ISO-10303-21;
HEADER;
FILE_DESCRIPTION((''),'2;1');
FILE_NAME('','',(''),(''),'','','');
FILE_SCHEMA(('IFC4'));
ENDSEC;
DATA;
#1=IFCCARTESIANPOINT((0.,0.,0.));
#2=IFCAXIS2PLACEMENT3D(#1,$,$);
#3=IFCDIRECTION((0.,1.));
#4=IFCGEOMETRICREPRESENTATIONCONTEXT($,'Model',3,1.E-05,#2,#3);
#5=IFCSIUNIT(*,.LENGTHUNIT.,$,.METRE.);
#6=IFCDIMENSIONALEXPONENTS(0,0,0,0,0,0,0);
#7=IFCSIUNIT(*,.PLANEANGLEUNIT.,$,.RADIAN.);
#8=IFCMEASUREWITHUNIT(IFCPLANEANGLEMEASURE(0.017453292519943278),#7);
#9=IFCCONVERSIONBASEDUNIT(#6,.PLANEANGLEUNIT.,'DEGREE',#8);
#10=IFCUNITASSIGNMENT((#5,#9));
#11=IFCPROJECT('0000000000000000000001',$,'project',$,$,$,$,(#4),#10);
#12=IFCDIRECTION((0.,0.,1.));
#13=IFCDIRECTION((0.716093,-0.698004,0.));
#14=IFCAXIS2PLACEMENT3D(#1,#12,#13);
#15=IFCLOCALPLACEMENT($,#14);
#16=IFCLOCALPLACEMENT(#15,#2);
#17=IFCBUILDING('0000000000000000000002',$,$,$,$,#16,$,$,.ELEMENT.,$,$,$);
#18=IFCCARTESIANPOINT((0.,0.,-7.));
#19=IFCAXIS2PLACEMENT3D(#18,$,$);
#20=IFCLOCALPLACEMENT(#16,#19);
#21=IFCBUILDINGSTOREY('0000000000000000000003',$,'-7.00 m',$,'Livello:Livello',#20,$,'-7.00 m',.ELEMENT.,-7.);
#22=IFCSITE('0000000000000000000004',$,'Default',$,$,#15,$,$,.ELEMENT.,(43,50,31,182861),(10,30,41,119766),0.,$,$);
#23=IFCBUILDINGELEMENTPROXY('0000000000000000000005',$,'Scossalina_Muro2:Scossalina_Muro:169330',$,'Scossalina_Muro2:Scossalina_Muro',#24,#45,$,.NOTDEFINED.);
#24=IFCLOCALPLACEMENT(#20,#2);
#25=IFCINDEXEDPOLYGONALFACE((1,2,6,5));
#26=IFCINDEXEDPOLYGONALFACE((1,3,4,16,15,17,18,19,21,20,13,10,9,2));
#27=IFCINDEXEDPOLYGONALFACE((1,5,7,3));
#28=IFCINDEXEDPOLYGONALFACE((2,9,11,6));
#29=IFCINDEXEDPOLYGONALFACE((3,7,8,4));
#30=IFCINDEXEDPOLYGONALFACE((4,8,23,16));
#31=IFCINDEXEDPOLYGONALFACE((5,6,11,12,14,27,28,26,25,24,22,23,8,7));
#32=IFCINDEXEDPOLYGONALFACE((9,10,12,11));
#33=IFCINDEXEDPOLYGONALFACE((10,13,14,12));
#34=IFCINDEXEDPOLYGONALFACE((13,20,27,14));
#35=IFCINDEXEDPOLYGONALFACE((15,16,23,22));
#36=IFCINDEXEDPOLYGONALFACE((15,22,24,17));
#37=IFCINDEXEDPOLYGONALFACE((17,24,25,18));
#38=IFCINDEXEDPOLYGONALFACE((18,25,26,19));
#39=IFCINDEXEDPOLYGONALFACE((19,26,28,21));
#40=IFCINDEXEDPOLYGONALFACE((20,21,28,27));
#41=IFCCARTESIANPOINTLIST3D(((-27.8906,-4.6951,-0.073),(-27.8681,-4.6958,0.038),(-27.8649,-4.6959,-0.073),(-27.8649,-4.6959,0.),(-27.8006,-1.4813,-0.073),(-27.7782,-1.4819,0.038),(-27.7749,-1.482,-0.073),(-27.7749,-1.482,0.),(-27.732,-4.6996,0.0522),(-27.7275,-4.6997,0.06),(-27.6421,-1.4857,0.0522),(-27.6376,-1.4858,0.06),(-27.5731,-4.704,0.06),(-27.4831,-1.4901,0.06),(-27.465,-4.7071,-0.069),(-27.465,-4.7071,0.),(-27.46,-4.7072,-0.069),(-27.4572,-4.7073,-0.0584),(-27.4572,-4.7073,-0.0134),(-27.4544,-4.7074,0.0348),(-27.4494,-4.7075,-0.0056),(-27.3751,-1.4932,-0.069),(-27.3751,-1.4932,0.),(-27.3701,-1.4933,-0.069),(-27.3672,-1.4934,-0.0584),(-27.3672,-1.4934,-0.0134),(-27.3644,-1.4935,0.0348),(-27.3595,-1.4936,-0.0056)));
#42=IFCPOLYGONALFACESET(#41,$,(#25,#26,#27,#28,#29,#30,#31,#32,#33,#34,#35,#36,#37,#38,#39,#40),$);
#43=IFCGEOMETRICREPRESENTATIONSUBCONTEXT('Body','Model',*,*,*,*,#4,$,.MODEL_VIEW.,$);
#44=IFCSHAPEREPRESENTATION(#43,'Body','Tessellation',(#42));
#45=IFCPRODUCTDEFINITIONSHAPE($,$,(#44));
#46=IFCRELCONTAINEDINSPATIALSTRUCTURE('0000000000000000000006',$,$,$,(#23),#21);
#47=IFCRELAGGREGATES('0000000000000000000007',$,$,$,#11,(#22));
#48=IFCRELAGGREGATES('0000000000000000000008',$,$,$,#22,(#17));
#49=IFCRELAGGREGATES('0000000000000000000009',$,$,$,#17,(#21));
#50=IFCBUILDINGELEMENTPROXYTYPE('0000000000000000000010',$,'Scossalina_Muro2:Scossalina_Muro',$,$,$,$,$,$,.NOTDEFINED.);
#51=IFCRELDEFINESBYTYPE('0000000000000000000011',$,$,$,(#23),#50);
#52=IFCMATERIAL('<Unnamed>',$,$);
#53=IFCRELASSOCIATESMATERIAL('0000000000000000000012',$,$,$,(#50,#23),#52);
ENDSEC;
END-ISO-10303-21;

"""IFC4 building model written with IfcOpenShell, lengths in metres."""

from ifc_helpers import new_model, entity, si_unit, converted_unit, direction, frame, origin, place, context, subcontext, project, spatial, indexed_curve, outline, extrude, source, transform, mapped, material, type_object, type_shapes, element, save


model = new_model("IFC4")

# Units and contexts
model_context = context("Model", 3, precision=1e-05, world=origin(), true_north=direction((0.0, 1.0)))
body_context = subcontext(model_context, "Body", "Model", "MODEL_VIEW")
ifc_project = project(units=[si_unit("LENGTHUNIT", "METRE"), converted_unit("PLANEANGLEUNIT", "DEGREE", entity("IfcPlaneAngleMeasure", 0.017453292519943278), si_unit("PLANEANGLEUNIT", "RADIAN"), dimensions=[0, 0, 0, 0, 0, 0, 0])], contexts=[model_context])

# Site, building, storey
site_placement = place(None, frame((0.0, 0.0, 0.0), z_axis=(0.0, 0.0, 1.0), x_axis=(0.716093, -0.698004, 0.0)))
site = spatial("IfcSite", under=ifc_project, at=site_placement, Name="Default", CompositionType="ELEMENT", RefLatitude=(43, 50, 31, 182861), RefLongitude=(10, 30, 41, 119766), RefElevation=0.0)
building_placement = place(site_placement, origin())
building = spatial("IfcBuilding", under=site, at=building_placement, CompositionType="ELEMENT")
storey_placement = place(building_placement, frame((0.0, 0.0, -7.0)))
storey = spatial("IfcBuildingStorey", under=building, at=storey_placement, Name="-7.00 m", ObjectType="Livello:Livello", LongName="-7.00 m", CompositionType="ELEMENT", Elevation=-7.0)

# Shared definitions
ifc_material_1 = material(Name="<Unnamed>")

# Building element proxy
building_element_proxy_type_1 = type_object("IfcBuildingElementProxyType", Name="Scossalina_Muro2:Scossalina_Muro", PredefinedType="NOTDEFINED", material=ifc_material_1)
shared_shape_1 = source(origin(), body_context, "Body", "SweptSolid", [
    extrude(outline(indexed_curve([(-0.104, -0.0683), (0.0505, -0.0683), (0.1692, -0.0431), (0.1742, -0.0027), (0.1664, 0.0051), (0.1664, 0.0501), (0.1636, 0.0607), (0.1586, 0.0607), (0.1586, -0.0083), (-0.2414, -0.0083), (-0.2414, 0.0647), (-0.2671, 0.0647), (-0.2447, -0.0463), (-0.1085, -0.0605), (-0.104, -0.0683)], self_intersect=False)), frame((-27.6235, -4.7026, -7.0083), z_axis=(0.02798, 0.999608, 0.0), x_axis=(0.999608, -0.02798, 0.0)), (0.0, 0.0, 1.0), 3.2151),
])
type_shapes(building_element_proxy_type_1, [shared_shape_1])
proxy_1_placement = place(storey_placement, frame((0.0, 0.0, 7.0)))
element("IfcBuildingElementProxy", 1, at=proxy_1_placement, inside=storey, type_object=building_element_proxy_type_1, material=ifc_material_1, Name="Scossalina_Muro2:Scossalina_Muro:169330", ObjectType="Scossalina_Muro2:Scossalina_Muro", PredefinedType="NOTDEFINED", context=body_context, shape_type="MappedRepresentation", body=[
    mapped(shared_shape_1, transform((0.0, 0.0, 0.0), scale=1.0)),
])

save(model, "model.ifc")
